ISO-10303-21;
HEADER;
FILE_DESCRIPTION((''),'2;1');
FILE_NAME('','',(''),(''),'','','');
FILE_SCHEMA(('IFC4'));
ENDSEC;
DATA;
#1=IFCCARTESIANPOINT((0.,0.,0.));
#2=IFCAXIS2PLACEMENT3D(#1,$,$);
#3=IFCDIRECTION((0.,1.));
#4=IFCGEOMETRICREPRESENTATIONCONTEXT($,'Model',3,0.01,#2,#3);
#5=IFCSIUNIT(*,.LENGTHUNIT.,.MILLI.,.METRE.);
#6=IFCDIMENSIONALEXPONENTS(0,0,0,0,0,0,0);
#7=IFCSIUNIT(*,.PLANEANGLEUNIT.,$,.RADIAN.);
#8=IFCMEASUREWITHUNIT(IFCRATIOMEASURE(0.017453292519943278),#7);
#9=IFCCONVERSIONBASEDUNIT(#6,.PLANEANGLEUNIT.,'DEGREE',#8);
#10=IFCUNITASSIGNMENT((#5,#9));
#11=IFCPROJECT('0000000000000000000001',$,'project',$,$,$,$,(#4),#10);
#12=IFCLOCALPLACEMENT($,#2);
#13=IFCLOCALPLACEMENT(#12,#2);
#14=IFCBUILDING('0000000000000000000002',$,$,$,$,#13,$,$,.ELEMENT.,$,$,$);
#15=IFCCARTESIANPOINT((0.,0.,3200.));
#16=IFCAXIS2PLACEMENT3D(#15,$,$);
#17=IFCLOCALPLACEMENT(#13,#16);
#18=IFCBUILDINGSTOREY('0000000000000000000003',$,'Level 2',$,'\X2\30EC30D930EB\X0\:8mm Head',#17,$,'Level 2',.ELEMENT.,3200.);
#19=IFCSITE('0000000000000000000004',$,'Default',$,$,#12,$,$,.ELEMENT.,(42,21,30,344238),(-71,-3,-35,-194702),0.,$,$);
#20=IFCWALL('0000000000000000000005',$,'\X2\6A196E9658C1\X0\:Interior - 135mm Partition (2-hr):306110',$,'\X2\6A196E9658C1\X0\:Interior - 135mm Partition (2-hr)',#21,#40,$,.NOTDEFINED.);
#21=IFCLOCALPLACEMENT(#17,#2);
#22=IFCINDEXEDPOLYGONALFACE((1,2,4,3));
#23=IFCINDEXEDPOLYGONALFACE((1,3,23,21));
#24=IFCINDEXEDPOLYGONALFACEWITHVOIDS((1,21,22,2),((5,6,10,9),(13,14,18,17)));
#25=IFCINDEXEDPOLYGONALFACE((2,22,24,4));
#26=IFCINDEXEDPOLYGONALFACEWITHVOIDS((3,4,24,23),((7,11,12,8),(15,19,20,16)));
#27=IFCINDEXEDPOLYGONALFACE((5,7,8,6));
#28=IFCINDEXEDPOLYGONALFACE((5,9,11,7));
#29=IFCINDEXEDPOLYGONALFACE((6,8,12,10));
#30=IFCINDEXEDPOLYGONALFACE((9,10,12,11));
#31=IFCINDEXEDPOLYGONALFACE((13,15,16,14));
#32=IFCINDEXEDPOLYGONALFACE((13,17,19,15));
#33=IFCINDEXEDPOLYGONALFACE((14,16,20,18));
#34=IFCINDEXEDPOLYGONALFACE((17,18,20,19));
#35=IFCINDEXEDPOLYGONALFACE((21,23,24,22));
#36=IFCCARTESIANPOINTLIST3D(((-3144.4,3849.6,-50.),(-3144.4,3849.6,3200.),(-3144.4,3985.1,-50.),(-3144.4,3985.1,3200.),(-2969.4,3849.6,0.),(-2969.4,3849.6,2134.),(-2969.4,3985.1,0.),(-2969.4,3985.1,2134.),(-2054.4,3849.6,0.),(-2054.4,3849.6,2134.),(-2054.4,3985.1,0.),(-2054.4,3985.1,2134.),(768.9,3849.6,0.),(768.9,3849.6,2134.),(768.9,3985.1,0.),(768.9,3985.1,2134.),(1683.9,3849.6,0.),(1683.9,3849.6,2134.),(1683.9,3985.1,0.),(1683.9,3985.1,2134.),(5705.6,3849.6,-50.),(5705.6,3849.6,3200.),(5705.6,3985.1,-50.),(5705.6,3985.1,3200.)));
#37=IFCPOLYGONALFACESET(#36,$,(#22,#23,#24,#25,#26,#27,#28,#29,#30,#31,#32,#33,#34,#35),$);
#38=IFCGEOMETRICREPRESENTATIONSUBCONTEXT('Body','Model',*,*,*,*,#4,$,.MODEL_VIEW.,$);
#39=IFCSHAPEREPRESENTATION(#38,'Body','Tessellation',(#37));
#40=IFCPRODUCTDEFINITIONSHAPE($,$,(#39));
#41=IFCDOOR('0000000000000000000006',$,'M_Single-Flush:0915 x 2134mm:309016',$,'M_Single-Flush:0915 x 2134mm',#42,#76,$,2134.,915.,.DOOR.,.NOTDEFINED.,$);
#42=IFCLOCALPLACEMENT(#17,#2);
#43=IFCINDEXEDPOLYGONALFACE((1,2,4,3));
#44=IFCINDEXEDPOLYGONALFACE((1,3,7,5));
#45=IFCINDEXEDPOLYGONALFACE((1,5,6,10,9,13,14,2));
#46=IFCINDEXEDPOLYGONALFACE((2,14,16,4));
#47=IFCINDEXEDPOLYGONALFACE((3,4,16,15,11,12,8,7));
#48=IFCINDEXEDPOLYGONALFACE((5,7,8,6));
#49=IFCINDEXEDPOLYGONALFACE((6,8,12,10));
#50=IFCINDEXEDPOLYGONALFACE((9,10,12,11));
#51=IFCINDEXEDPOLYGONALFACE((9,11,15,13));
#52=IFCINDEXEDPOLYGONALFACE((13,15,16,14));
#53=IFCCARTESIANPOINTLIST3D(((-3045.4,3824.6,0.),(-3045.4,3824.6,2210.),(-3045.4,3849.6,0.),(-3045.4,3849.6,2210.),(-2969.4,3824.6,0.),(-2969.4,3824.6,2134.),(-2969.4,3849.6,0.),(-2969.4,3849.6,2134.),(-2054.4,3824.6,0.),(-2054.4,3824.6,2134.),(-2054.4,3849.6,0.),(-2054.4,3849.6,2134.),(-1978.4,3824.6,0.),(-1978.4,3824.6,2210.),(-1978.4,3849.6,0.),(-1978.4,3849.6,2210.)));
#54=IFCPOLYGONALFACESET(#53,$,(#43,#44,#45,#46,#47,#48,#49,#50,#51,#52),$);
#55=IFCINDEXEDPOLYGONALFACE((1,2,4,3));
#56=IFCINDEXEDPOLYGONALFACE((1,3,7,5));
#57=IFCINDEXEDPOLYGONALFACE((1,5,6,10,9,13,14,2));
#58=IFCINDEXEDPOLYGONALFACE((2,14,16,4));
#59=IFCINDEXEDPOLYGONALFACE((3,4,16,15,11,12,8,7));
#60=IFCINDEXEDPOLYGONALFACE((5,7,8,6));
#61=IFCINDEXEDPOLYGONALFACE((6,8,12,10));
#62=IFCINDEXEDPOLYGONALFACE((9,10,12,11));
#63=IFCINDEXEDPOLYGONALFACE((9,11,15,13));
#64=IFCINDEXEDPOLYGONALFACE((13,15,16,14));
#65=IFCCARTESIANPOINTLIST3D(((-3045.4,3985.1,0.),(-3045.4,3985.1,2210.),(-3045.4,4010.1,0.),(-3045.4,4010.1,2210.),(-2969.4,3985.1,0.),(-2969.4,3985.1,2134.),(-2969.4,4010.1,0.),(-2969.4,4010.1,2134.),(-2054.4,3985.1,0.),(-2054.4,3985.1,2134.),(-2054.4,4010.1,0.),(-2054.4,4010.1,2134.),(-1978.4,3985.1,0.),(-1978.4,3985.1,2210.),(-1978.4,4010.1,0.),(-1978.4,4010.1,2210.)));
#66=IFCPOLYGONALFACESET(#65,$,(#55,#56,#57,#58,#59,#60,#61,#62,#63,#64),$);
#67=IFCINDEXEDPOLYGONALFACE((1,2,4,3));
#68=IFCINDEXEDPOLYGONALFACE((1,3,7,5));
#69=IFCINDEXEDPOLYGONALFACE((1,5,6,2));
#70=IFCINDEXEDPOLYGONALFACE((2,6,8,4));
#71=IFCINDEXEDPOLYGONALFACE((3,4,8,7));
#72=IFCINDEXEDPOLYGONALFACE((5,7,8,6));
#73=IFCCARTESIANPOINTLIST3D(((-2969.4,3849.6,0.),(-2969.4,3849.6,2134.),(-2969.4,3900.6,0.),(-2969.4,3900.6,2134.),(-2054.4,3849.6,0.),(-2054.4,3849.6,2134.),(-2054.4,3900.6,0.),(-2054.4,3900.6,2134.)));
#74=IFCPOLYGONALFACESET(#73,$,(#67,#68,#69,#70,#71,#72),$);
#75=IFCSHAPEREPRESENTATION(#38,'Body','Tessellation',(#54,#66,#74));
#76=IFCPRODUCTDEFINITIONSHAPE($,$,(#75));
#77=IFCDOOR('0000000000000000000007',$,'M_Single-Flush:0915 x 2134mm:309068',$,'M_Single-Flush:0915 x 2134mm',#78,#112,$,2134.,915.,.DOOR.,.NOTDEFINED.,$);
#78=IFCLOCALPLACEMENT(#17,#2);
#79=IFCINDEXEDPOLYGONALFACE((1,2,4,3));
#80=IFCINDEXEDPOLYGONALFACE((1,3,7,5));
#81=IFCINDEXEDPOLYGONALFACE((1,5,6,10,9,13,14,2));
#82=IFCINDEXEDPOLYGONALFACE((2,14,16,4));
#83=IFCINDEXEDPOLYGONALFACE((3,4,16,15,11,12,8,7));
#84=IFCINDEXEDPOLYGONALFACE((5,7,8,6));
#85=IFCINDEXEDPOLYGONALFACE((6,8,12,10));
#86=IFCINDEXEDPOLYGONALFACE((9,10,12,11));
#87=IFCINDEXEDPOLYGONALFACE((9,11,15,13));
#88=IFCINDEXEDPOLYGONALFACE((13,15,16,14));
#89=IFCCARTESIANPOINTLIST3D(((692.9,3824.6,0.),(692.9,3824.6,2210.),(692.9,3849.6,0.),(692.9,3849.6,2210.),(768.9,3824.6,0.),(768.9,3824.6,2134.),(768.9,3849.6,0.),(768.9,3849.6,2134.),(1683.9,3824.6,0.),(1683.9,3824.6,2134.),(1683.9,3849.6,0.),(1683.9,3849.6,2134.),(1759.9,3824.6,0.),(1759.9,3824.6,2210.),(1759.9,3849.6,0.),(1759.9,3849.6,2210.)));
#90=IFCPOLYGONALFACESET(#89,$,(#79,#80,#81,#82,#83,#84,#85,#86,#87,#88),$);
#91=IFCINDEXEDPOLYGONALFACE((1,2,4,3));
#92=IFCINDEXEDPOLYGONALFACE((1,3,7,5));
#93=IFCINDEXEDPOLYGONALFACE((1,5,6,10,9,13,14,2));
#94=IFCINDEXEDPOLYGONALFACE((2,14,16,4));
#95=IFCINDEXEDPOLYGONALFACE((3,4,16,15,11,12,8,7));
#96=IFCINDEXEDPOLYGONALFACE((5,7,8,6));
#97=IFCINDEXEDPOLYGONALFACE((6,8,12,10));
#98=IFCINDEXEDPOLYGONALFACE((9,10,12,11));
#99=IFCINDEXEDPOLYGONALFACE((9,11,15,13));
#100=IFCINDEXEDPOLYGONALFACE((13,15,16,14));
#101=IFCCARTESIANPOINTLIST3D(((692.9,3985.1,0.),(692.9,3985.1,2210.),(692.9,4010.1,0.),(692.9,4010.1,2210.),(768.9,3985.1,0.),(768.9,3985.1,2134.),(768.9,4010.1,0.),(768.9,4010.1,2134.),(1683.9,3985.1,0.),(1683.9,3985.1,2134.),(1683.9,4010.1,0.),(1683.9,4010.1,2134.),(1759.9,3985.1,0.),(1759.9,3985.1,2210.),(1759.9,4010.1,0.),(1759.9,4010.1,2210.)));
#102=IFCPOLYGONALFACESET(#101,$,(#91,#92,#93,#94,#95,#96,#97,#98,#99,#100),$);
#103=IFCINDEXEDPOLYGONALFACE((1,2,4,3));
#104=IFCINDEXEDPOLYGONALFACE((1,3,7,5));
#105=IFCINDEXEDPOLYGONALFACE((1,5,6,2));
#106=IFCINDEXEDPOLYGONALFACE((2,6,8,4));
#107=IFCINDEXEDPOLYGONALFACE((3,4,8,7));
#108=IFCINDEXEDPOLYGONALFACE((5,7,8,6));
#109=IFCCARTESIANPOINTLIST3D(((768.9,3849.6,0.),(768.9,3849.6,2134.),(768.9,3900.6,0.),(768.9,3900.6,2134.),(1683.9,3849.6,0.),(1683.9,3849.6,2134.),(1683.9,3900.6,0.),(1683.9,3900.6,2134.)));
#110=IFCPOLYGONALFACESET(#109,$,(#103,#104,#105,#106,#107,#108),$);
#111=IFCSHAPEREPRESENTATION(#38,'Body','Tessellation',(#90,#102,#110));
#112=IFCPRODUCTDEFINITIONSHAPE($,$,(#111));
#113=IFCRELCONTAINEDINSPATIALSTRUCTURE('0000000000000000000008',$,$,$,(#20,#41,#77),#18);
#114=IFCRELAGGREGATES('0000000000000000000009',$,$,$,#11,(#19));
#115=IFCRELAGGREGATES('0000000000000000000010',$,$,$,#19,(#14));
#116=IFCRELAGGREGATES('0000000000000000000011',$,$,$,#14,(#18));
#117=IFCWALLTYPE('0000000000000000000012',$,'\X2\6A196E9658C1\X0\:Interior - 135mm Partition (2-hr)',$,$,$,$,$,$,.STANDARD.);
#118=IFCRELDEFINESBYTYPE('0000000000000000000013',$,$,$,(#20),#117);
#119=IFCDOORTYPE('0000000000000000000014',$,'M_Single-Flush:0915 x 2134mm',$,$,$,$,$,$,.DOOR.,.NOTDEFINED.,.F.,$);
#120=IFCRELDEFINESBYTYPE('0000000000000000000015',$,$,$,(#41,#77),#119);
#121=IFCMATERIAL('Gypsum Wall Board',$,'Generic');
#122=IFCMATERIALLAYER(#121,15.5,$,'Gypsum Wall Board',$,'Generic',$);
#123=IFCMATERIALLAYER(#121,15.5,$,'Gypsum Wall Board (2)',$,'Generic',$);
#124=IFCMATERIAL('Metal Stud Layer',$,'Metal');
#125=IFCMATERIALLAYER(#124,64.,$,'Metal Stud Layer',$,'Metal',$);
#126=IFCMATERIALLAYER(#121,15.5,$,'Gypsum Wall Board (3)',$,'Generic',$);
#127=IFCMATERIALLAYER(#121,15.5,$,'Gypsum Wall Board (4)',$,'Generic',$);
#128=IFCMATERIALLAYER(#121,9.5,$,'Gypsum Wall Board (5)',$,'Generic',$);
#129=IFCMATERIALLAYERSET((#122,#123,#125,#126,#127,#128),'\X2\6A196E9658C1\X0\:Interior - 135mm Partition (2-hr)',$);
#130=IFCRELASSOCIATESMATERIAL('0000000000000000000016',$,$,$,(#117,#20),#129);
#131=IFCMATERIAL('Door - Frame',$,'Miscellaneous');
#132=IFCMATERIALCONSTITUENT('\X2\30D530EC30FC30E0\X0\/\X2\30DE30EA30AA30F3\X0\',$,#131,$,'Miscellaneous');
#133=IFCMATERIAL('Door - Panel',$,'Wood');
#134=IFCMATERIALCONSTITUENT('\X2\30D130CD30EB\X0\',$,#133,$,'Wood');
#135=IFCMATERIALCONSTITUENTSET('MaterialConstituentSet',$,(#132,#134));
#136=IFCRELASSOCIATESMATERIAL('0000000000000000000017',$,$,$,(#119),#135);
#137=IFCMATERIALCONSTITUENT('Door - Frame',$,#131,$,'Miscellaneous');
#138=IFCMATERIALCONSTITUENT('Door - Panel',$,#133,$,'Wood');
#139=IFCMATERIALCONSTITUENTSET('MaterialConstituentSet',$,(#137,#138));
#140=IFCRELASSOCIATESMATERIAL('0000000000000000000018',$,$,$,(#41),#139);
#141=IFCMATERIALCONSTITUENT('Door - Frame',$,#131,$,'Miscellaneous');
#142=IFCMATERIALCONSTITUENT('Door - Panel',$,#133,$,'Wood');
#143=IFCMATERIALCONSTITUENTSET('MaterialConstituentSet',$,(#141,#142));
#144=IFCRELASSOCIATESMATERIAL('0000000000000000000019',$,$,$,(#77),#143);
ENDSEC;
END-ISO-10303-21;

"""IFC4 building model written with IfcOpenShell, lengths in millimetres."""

from ifc_helpers import new_model, entity, si_unit, converted_unit, direction, frame, frame_2d, origin, place, context, subcontext, project, spatial, polyline, rectangle, outline, extrude, source, transform, mapped, material, layer, layer_set, layer_usage, constituent, constituent_set, type_object, type_shapes, element, fill, save


model = new_model("IFC4")

# Units and contexts
model_context = context("Model", 3, precision=0.01, world=origin(), true_north=direction((0.0, 1.0)))
body_context = subcontext(model_context, "Body", "Model", "MODEL_VIEW")
ifc_project = project(units=[si_unit("LENGTHUNIT", "METRE", prefix="MILLI"), converted_unit("PLANEANGLEUNIT", "DEGREE", entity("IfcRatioMeasure", 0.017453292519943278), si_unit("PLANEANGLEUNIT", "RADIAN"), dimensions=[0, 0, 0, 0, 0, 0, 0])], contexts=[model_context])

# Site, building, storey
site_placement = place(None, origin())
site = spatial("IfcSite", under=ifc_project, at=site_placement, Name="Default", CompositionType="ELEMENT", RefLatitude=(42, 21, 30, 344238), RefLongitude=(-71, -3, -35, -194702), RefElevation=0.0)
building_placement = place(site_placement, origin())
building = spatial("IfcBuilding", under=site, at=building_placement, CompositionType="ELEMENT")
storey_placement = place(building_placement, frame((0.0, 0.0, 3200.0)))
storey = spatial("IfcBuildingStorey", under=building, at=storey_placement, Name="Level 2", ObjectType="レベル:8mm Head", LongName="Level 2", CompositionType="ELEMENT", Elevation=3200.0)

# Wall, openings, doors
ifc_material_1 = material(Name="Gypsum Wall Board", Category="Generic")
ifc_layer_1 = layer(ifc_material_1, 15.5, Name="Gypsum Wall Board", Category="Generic")
ifc_layer_2 = layer(ifc_material_1, 15.5, Name="Gypsum Wall Board (2)", Category="Generic")
ifc_material_2 = material(Name="Metal Stud Layer", Category="Metal")
ifc_layer_3 = layer(ifc_material_2, 64.0, Name="Metal Stud Layer", Category="Metal")
ifc_layer_4 = layer(ifc_material_1, 15.5, Name="Gypsum Wall Board (3)", Category="Generic")
ifc_layer_5 = layer(ifc_material_1, 15.5, Name="Gypsum Wall Board (4)", Category="Generic")
ifc_layer_6 = layer(ifc_material_1, 9.5, Name="Gypsum Wall Board (5)", Category="Generic")
ifc_layer_set_1 = layer_set([ifc_layer_1, ifc_layer_2, ifc_layer_3, ifc_layer_4, ifc_layer_5, ifc_layer_6], Name="標準壁:Interior - 135mm Partition (2-hr)")
ifc_layer_usage_1 = layer_usage(ifc_layer_set_1, "AXIS2", "NEGATIVE", 67.8)
wall_type = type_object("IfcWallType", Name="標準壁:Interior - 135mm Partition (2-hr)", PredefinedType="STANDARD", material=ifc_layer_set_1)
wall_1_placement = place(storey_placement, frame((-3144.4, 3917.4, -50.0)))
wall_1 = element("IfcWall", 1, at=wall_1_placement, inside=storey, type_object=wall_type, material=ifc_layer_usage_1, Name="標準壁:Interior - 135mm Partition (2-hr):306110", ObjectType="標準壁:Interior - 135mm Partition (2-hr)", PredefinedType="NOTDEFINED", context=body_context, shape_type="SweptSolid", body=[
    extrude(rectangle(XDim=8850.0, YDim=135.5, at=frame_2d((4425.0, 0.0), x_axis=(-1.0, 0.0))), origin(), (0.0, 0.0, 1.0), 3250.0),
])
opening_1_placement = place(wall_1_placement, frame((1090.0, 67.7, 50.0)))
opening_1 = element("IfcOpeningElement", 2, at=opening_1_placement, cuts=wall_1, PredefinedType="OPENING", context=body_context, shape_type="SweptSolid", body=[
    extrude(rectangle(XDim=915.0, YDim=2134.0, at=frame_2d((1067.0, 457.5), x_axis=(0.0, 1.0))), frame((0.0, 0.0, 0.0), z_axis=(0.0, -1.0, 0.0), x_axis=(0.0, 0.0, 1.0)), (0.0, 0.0, 1.0), 135.5),
])
opening_2_placement = place(wall_1_placement, frame((4828.3, 67.7, 50.0)))
opening_2 = element("IfcOpeningElement", 3, at=opening_2_placement, cuts=wall_1, PredefinedType="OPENING", context=body_context, shape_type="SweptSolid", body=[
    extrude(rectangle(XDim=915.0, YDim=2134.0, at=frame_2d((1067.0, 457.5), x_axis=(0.0, 1.0))), frame((0.0, 0.0, 0.0), z_axis=(0.0, -1.0, 0.0), x_axis=(0.0, 0.0, 1.0)), (0.0, 0.0, 1.0), 135.5),
])
ifc_material_3 = material(Name="Door - Frame", Category="Miscellaneous")
ifc_constituent_1 = constituent(ifc_material_3, Name="Door - Frame", Category="Miscellaneous")
ifc_material_4 = material(Name="Door - Panel", Category="Wood")
ifc_constituent_2 = constituent(ifc_material_4, Name="Door - Panel", Category="Wood")
ifc_constituent_set_1 = constituent_set(constituents=[ifc_constituent_1, ifc_constituent_2], Name="MaterialConstituentSet")
ifc_constituent_3 = constituent(ifc_material_3, Name="フレーム/マリオン", Category="Miscellaneous")
ifc_constituent_4 = constituent(ifc_material_4, Name="パネル", Category="Wood")
ifc_constituent_set_2 = constituent_set(constituents=[ifc_constituent_3, ifc_constituent_4], Name="MaterialConstituentSet")
door_type_1 = type_object("IfcDoorType", Name="M_Single-Flush:0915 x 2134mm", OperationType="NOTDEFINED", ParameterTakesPrecedence=False, PredefinedType="DOOR", material=ifc_constituent_set_2)
shared_shape_1 = source(origin(), body_context, "Body", "SweptSolid", [
    extrude(outline(polyline([(-533.5, -1124.0), (533.5, -1124.0), (533.5, 1086.0), (457.5, 1086.0), (457.5, -1048.0), (-457.5, -1048.0), (-457.5, 1086.0), (-533.5, 1086.0), (-533.5, -1124.0)])), frame((457.5, 135.5, 1086.0), z_axis=(0.0, 1.0, 0.0), x_axis=(1.0, 0.0, 0.0)), (0.0, 0.0, 1.0), 25.0),
    extrude(outline(polyline([(-1124.0, -533.5), (1086.0, -533.5), (1086.0, -457.5), (-1048.0, -457.5), (-1048.0, 457.5), (1086.0, 457.5), (1086.0, 533.5), (-1124.0, 533.5), (-1124.0, -533.5)])), frame((457.5, -25.0, 1086.0), z_axis=(0.0, 1.0, 0.0), x_axis=(0.0, 0.0, -1.0)), (0.0, 0.0, 1.0), 25.0),
    extrude(rectangle(XDim=51.0, YDim=915.0, at=frame_2d((0.0, 0.0), x_axis=(1.0, 0.0))), frame((457.5, 110.0, 0.0), z_axis=(0.0, 0.0, 1.0), x_axis=(0.0, 1.0, 0.0)), (0.0, 0.0, 1.0), 2134.0),
])
type_shapes(door_type_1, [shared_shape_1])
door_1_placement = place(opening_1_placement, frame((0.0, 0.0, 0.0), z_axis=(0.0, 0.0, 1.0), x_axis=(-1.0, 0.0, 0.0)))
door_1 = element("IfcDoor", 4, at=door_1_placement, inside=storey, type_object=door_type_1, material=ifc_constituent_set_1, Name="M_Single-Flush:0915 x 2134mm:309016", ObjectType="M_Single-Flush:0915 x 2134mm", OperationType="NOTDEFINED", OverallHeight=2134.0, OverallWidth=915.0, PredefinedType="DOOR", context=body_context, shape_type="MappedRepresentation", body=[
    mapped(shared_shape_1, transform((0.0, 0.0, 0.0), scale=1.0)),
])
fill(opening_1, door_1)
ifc_constituent_5 = constituent(ifc_material_3, Name="Door - Frame", Category="Miscellaneous")
ifc_constituent_6 = constituent(ifc_material_4, Name="Door - Panel", Category="Wood")
ifc_constituent_set_3 = constituent_set(constituents=[ifc_constituent_5, ifc_constituent_6], Name="MaterialConstituentSet")
door_2_placement = place(opening_2_placement, frame((0.0, 0.0, 0.0), z_axis=(0.0, 0.0, 1.0), x_axis=(-1.0, 0.0, 0.0)))
door_2 = element("IfcDoor", 5, at=door_2_placement, inside=storey, type_object=door_type_1, material=ifc_constituent_set_3, Name="M_Single-Flush:0915 x 2134mm:309068", ObjectType="M_Single-Flush:0915 x 2134mm", OperationType="NOTDEFINED", OverallHeight=2134.0, OverallWidth=915.0, PredefinedType="DOOR", context=body_context, shape_type="MappedRepresentation", body=[
    mapped(shared_shape_1, transform((0.0, 0.0, 0.0), scale=1.0)),
])
fill(opening_2, door_2)

save(model, "model.ifc")
